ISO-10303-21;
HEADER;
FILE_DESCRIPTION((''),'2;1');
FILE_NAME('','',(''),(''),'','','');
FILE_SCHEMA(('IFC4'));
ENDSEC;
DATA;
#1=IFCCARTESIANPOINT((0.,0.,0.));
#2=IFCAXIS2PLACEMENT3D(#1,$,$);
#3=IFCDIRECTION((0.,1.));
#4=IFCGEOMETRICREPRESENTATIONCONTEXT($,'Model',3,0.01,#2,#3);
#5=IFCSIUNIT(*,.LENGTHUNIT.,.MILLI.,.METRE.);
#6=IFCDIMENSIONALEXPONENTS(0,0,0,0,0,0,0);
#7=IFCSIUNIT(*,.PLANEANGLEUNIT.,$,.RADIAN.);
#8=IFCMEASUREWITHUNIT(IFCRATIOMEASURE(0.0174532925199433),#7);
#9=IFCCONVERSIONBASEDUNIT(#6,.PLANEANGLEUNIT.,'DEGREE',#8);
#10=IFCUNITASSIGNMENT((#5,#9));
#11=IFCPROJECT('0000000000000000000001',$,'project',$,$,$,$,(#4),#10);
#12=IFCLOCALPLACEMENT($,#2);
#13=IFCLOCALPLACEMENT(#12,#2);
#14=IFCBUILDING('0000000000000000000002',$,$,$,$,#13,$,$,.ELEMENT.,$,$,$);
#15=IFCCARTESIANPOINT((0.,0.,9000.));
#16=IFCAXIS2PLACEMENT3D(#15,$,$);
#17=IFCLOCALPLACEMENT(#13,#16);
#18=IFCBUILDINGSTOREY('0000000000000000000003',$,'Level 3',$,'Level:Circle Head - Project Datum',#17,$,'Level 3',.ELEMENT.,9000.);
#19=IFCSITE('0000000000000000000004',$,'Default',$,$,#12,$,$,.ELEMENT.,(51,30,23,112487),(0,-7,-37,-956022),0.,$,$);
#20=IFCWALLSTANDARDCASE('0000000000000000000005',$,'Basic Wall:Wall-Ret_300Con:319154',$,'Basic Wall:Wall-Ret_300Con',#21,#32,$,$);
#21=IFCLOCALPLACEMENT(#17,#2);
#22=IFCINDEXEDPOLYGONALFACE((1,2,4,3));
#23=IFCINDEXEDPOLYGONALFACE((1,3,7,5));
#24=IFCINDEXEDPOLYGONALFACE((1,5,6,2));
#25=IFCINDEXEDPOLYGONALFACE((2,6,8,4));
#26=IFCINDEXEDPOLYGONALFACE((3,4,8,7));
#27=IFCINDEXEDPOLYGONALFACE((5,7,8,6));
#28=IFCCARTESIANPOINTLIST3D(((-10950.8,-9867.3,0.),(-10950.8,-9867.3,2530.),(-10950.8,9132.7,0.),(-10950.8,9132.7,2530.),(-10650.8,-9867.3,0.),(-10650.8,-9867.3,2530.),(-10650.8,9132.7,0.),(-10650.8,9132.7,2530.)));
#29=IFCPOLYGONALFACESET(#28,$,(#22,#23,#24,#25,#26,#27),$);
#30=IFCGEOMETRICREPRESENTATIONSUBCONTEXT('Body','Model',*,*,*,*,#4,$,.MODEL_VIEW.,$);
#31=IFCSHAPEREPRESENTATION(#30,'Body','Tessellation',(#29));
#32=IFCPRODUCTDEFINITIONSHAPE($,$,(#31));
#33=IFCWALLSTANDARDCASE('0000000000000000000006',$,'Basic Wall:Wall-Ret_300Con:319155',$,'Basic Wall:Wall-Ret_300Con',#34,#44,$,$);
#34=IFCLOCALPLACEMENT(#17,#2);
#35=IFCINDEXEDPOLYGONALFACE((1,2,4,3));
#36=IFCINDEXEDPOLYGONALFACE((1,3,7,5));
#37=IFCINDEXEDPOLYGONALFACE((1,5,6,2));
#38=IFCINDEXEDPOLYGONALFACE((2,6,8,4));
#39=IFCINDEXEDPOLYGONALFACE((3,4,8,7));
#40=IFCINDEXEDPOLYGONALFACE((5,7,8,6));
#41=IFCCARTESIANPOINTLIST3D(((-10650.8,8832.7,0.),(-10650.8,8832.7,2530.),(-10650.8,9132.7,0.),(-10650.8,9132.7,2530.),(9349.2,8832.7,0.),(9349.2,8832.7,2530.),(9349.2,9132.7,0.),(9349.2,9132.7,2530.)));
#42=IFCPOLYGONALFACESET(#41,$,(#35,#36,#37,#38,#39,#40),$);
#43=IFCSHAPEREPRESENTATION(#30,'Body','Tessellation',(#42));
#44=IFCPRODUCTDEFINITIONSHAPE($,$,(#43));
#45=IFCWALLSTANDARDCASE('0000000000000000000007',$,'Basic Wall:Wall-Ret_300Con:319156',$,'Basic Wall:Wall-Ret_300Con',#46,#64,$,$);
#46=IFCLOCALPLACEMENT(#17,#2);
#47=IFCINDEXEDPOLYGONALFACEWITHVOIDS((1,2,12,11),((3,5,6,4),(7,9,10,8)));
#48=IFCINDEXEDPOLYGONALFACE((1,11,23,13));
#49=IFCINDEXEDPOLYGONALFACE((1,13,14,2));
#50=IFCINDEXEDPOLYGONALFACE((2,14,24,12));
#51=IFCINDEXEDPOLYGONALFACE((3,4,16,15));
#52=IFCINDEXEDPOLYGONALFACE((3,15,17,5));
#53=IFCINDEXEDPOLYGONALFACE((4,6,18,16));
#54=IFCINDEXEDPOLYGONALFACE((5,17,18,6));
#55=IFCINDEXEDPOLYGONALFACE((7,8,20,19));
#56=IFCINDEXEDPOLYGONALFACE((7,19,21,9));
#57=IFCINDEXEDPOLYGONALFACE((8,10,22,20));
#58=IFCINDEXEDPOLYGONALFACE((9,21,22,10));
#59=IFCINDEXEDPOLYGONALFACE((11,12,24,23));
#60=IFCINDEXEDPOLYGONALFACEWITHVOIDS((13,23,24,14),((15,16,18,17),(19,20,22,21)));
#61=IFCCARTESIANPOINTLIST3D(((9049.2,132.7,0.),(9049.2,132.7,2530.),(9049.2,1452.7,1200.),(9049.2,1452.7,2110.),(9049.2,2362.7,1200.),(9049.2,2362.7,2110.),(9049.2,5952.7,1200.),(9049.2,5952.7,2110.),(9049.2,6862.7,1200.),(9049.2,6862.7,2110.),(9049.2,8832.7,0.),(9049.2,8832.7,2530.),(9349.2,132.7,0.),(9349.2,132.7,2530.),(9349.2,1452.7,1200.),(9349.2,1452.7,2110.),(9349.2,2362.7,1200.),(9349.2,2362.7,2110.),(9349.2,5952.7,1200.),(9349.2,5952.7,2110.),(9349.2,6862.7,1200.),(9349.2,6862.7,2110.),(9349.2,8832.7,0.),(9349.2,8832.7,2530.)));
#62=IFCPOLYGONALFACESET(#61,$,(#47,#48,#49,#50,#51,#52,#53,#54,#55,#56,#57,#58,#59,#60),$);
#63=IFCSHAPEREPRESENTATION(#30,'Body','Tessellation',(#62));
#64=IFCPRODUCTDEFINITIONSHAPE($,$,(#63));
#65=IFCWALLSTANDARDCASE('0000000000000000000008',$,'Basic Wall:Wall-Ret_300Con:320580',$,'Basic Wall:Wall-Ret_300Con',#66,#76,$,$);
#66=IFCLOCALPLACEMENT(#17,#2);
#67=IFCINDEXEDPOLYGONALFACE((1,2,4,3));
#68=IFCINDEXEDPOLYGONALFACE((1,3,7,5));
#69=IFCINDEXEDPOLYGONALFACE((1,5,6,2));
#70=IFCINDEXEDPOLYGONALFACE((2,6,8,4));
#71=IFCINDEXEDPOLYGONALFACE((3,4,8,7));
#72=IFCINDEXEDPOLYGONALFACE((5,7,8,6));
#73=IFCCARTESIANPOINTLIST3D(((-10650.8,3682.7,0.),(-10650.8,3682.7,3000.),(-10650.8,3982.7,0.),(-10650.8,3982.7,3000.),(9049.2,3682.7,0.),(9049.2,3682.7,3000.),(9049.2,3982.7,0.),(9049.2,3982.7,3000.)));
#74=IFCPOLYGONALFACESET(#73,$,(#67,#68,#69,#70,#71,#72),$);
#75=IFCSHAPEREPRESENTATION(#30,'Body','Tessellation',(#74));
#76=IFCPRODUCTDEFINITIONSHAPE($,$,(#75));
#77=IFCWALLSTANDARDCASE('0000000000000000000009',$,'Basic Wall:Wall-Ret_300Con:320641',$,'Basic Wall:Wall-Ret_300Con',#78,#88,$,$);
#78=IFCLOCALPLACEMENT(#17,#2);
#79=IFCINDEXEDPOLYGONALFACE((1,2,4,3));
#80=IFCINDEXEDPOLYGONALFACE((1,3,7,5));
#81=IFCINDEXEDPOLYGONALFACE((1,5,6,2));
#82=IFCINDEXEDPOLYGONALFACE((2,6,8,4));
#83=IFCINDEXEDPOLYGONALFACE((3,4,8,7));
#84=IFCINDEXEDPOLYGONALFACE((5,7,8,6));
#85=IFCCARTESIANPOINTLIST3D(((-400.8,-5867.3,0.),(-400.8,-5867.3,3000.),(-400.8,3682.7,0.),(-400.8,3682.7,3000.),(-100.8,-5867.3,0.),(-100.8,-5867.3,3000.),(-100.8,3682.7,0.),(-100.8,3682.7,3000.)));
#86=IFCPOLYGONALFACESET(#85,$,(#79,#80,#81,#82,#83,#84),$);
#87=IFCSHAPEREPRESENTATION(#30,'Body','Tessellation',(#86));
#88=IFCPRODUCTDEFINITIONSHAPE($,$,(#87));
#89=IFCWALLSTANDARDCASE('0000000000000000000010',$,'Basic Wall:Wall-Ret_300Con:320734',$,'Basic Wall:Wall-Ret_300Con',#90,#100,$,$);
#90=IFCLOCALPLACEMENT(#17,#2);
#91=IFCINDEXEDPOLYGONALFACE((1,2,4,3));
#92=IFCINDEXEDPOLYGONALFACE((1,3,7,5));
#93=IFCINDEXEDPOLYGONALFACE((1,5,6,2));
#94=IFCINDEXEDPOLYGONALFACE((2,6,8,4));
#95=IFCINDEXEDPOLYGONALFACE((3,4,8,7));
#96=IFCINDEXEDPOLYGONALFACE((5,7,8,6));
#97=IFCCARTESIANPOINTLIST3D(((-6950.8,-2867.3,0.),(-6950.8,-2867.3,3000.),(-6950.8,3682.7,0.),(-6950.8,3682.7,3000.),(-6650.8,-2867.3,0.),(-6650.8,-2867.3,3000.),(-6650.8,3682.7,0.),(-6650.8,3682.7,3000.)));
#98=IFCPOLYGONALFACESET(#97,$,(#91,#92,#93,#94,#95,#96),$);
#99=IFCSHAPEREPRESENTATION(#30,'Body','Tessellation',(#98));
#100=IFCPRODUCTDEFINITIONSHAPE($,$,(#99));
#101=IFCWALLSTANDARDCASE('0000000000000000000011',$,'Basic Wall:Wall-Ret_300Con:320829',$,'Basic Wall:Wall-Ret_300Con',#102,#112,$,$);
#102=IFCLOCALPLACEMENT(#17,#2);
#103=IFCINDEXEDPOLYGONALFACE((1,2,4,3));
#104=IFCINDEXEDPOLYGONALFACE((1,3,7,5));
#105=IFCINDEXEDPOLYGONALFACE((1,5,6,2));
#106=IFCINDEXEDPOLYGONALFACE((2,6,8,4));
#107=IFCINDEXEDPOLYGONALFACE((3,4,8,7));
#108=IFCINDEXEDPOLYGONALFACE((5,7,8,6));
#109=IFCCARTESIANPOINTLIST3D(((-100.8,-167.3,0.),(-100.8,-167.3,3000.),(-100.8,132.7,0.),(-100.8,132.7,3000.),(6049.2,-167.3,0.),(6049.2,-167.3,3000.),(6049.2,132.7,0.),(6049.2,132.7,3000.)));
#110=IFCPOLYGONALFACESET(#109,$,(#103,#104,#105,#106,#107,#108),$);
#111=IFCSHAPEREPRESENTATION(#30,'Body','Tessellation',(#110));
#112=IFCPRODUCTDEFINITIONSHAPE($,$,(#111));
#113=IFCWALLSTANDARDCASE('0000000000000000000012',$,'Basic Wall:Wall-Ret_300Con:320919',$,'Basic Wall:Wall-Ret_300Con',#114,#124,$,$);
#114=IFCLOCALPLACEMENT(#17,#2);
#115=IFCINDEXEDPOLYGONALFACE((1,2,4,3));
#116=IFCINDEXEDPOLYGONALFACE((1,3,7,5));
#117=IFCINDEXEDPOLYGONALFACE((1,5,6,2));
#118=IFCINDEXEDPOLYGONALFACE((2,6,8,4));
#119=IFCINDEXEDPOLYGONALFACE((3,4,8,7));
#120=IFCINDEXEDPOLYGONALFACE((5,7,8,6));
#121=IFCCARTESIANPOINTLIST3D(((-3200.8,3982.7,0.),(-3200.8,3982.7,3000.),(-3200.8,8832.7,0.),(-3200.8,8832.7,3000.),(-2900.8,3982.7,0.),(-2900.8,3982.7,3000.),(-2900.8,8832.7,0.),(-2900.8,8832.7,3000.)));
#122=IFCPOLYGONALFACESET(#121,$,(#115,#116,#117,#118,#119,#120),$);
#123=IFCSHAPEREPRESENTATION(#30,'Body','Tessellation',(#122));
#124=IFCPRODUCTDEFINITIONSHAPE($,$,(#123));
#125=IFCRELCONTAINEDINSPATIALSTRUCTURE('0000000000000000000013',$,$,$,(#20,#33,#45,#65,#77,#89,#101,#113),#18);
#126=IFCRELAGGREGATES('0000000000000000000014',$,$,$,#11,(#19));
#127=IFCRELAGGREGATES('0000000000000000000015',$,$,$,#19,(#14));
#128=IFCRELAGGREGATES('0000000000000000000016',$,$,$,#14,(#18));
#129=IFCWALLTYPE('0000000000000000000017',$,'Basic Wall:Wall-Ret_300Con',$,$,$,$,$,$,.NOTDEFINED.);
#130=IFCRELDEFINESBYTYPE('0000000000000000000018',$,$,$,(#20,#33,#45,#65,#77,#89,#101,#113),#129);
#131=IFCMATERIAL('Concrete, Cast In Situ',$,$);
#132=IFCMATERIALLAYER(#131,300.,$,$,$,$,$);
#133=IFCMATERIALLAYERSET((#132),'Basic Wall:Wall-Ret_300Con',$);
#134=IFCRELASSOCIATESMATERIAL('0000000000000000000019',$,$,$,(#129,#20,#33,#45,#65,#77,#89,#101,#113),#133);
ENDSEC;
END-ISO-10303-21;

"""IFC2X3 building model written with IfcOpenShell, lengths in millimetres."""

from ifc_helpers import new_model, entity, si_unit, converted_unit, direction, frame, frame_2d, origin, place, context, subcontext, project, spatial, polyline, rectangle, extrude, clip, bounded_halfspace, material, layer, layer_set, layer_usage, type_object, element, save


model = new_model("IFC2X3")

# Units and contexts
model_context = context("Model", 3, precision=0.01, world=origin(), true_north=direction((0.0, 1.0)))
body_context = subcontext(model_context, "Body", "Model", "MODEL_VIEW")
ifc_project = project(units=[si_unit("LENGTHUNIT", "METRE", prefix="MILLI"), converted_unit("PLANEANGLEUNIT", "DEGREE", entity("IfcRatioMeasure", 0.0174532925199433), si_unit("PLANEANGLEUNIT", "RADIAN"), dimensions=[0, 0, 0, 0, 0, 0, 0])], contexts=[model_context])

# Site, building, storey
site_placement = place(None, origin())
site = spatial("IfcSite", under=ifc_project, at=site_placement, Name="Default", CompositionType="ELEMENT", RefLatitude=(51, 30, 23, 112487), RefLongitude=(0, -7, -37, -956022), RefElevation=0.0)
building_placement = place(site_placement, origin())
building = spatial("IfcBuilding", under=site, at=building_placement, CompositionType="ELEMENT")
storey_placement = place(building_placement, frame((0.0, 0.0, 9000.0)))
storey = spatial("IfcBuildingStorey", under=building, at=storey_placement, Name="Level 3", ObjectType="Level:Circle Head - Project Datum", LongName="Level 3", CompositionType="ELEMENT", Elevation=9000.0)

# Shared definitions
ifc_material_1 = material(Name="Concrete, Cast In Situ")
ifc_layer_1 = layer(ifc_material_1, 300.0)
ifc_layer_set_1 = layer_set([ifc_layer_1], Name="Basic Wall:Wall-Ret_300Con")
wall_type = type_object("IfcWallType", Name="Basic Wall:Wall-Ret_300Con", PredefinedType="NOTDEFINED", material=ifc_layer_set_1)

# Walls
ifc_layer_usage_1 = layer_usage(ifc_layer_set_1, "AXIS2", "NEGATIVE", 150.0)
wall_1_placement = place(storey_placement, frame((-10800.8, -9867.3, 0.0), z_axis=(0.0, 0.0, 1.0), x_axis=(0.0, 1.0, 0.0)))
element("IfcWallStandardCase", 1, at=wall_1_placement, inside=storey, type_object=wall_type, material=ifc_layer_usage_1, Name="Basic Wall:Wall-Ret_300Con:319154", ObjectType="Basic Wall:Wall-Ret_300Con", context=body_context, shape_type="Clipping", body=[
    clip(extrude(rectangle(XDim=19000.0, YDim=300.0, at=frame_2d((9500.0, 0.0), x_axis=(-1.0, 0.0))), origin(), (0.0, 0.0, 1.0), 2530.0), bounded_halfspace(frame((0.0, -150.0, 2530.0), z_axis=(0.0, 0.0, -1.0), x_axis=(0.0, -1.0, 0.0)), True, frame((0.0, -150.0, 2530.0)), polyline([(0.0, 0.0), (18700.0, 0.0), (19000.0, 0.0), (19000.0, 300.0), (0.0, 300.0), (0.0, 0.0)]))),
])
ifc_layer_usage_2 = layer_usage(ifc_layer_set_1, "AXIS2", "NEGATIVE", 150.0)
wall_2_placement = place(storey_placement, frame((-10650.8, 8982.7, 0.0)))
element("IfcWallStandardCase", 2, at=wall_2_placement, inside=storey, type_object=wall_type, material=ifc_layer_usage_2, Name="Basic Wall:Wall-Ret_300Con:319155", ObjectType="Basic Wall:Wall-Ret_300Con", context=body_context, shape_type="Clipping", body=[
    clip(extrude(rectangle(XDim=20000.0, YDim=300.0, at=frame_2d((10000.0, 0.0), x_axis=(-1.0, 0.0))), origin(), (0.0, 0.0, 1.0), 2530.0), bounded_halfspace(frame((0.0, -150.0, 2530.0), z_axis=(0.0, 0.0, -1.0), x_axis=(1.0, 0.0, 0.0)), True, frame((0.0, -150.0, 2530.0)), polyline([(0.0, 0.0), (19700.0, 0.0), (19998.7, 0.0), (19998.7, 300.0), (0.0, 300.0), (0.0, 0.0)]))),
])

# Wall, openings
ifc_layer_usage_3 = layer_usage(ifc_layer_set_1, "AXIS2", "NEGATIVE", 150.0)
wall_3_placement = place(storey_placement, frame((9199.2, 8832.7, 0.0), z_axis=(0.0, 0.0, 1.0), x_axis=(0.0, -1.0, 0.0)))
wall_3 = element("IfcWallStandardCase", 3, at=wall_3_placement, inside=storey, type_object=wall_type, material=ifc_layer_usage_3, Name="Basic Wall:Wall-Ret_300Con:319156", ObjectType="Basic Wall:Wall-Ret_300Con", context=body_context, shape_type="Clipping", body=[
    clip(extrude(rectangle(XDim=8700.0, YDim=300.0, at=frame_2d((4350.0, 0.0), x_axis=(-1.0, 0.0))), origin(), (0.0, 0.0, 1.0), 2530.0), bounded_halfspace(frame((0.0, -150.0, 2530.0), z_axis=(0.0, 0.0, -1.0), x_axis=(0.0, 1.0, 0.0)), True, frame((0.0, -150.0, 2530.0)), polyline([(0.0, 0.0), (8700.0, 0.0), (8700.0, 298.7), (0.0, 298.7), (0.0, 0.0)]))),
])
opening_1_placement = place(wall_3_placement, frame((1970.0, -150.0, 1200.0)))
element("IfcOpeningElement", 4, at=opening_1_placement, cuts=wall_3, ObjectType="Opening", context=body_context, shape_type="SweptSolid", body=[
    extrude(rectangle(XDim=910.0, YDim=910.0, at=frame_2d((455.0, 455.0), x_axis=(-1.0, 0.0))), frame((0.0, 0.0, 0.0), z_axis=(0.0, 1.0, 0.0), x_axis=(0.0, 0.0, 1.0)), (0.0, 0.0, 1.0), 300.0),
])
opening_2_placement = place(wall_3_placement, frame((6470.0, -150.0, 1200.0)))
element("IfcOpeningElement", 5, at=opening_2_placement, cuts=wall_3, ObjectType="Opening", context=body_context, shape_type="SweptSolid", body=[
    extrude(rectangle(XDim=910.0, YDim=910.0, at=frame_2d((455.0, 455.0), x_axis=(-1.0, 0.0))), frame((0.0, 0.0, 0.0), z_axis=(0.0, 1.0, 0.0), x_axis=(0.0, 0.0, 1.0)), (0.0, 0.0, 1.0), 300.0),
])

# Walls
ifc_layer_usage_4 = layer_usage(ifc_layer_set_1, "AXIS2", "NEGATIVE", 150.0)
wall_4_placement = place(storey_placement, frame((-10650.8, 3832.7, 0.0)))
element("IfcWallStandardCase", 6, at=wall_4_placement, inside=storey, type_object=wall_type, material=ifc_layer_usage_4, Name="Basic Wall:Wall-Ret_300Con:320580", ObjectType="Basic Wall:Wall-Ret_300Con", context=body_context, shape_type="SweptSolid", body=[
    extrude(rectangle(XDim=19700.0, YDim=300.0, at=frame_2d((9850.0, 0.0), x_axis=(-1.0, 0.0))), origin(), (0.0, 0.0, 1.0), 3000.0),
])
ifc_layer_usage_5 = layer_usage(ifc_layer_set_1, "AXIS2", "NEGATIVE", 150.0)
wall_5_placement = place(storey_placement, frame((-250.8, 3682.7, 0.0), z_axis=(0.0, 0.0, 1.0), x_axis=(0.0, -1.0, 0.0)))
element("IfcWallStandardCase", 7, at=wall_5_placement, inside=storey, type_object=wall_type, material=ifc_layer_usage_5, Name="Basic Wall:Wall-Ret_300Con:320641", ObjectType="Basic Wall:Wall-Ret_300Con", context=body_context, shape_type="SweptSolid", body=[
    extrude(rectangle(XDim=9550.0, YDim=300.0, at=frame_2d((4775.0, 0.0), x_axis=(-1.0, 0.0))), origin(), (0.0, 0.0, 1.0), 3000.0),
])
ifc_layer_usage_6 = layer_usage(ifc_layer_set_1, "AXIS2", "NEGATIVE", 150.0)
wall_6_placement = place(storey_placement, frame((-6800.8, -2867.3, 0.0), z_axis=(0.0, 0.0, 1.0), x_axis=(0.0, 1.0, 0.0)))
element("IfcWallStandardCase", 8, at=wall_6_placement, inside=storey, type_object=wall_type, material=ifc_layer_usage_6, Name="Basic Wall:Wall-Ret_300Con:320734", ObjectType="Basic Wall:Wall-Ret_300Con", context=body_context, shape_type="SweptSolid", body=[
    extrude(rectangle(XDim=6550.0, YDim=300.0, at=frame_2d((3275.0, 0.0), x_axis=(-1.0, 0.0))), origin(), (0.0, 0.0, 1.0), 3000.0),
])
ifc_layer_usage_7 = layer_usage(ifc_layer_set_1, "AXIS2", "NEGATIVE", 150.0)
wall_7_placement = place(storey_placement, frame((6049.2, -17.3, 0.0), z_axis=(0.0, 0.0, 1.0), x_axis=(-1.0, 0.0, 0.0)))
element("IfcWallStandardCase", 9, at=wall_7_placement, inside=storey, type_object=wall_type, material=ifc_layer_usage_7, Name="Basic Wall:Wall-Ret_300Con:320829", ObjectType="Basic Wall:Wall-Ret_300Con", context=body_context, shape_type="SweptSolid", body=[
    extrude(rectangle(XDim=6150.0, YDim=300.0, at=frame_2d((3075.0, 0.0), x_axis=(-1.0, 0.0))), origin(), (0.0, 0.0, 1.0), 3000.0),
])
ifc_layer_usage_8 = layer_usage(ifc_layer_set_1, "AXIS2", "NEGATIVE", 150.0)
wall_8_placement = place(storey_placement, frame((-3050.8, 3982.7, 0.0), z_axis=(0.0, 0.0, 1.0), x_axis=(0.0, 1.0, 0.0)))
element("IfcWallStandardCase", 10, at=wall_8_placement, inside=storey, type_object=wall_type, material=ifc_layer_usage_8, Name="Basic Wall:Wall-Ret_300Con:320919", ObjectType="Basic Wall:Wall-Ret_300Con", context=body_context, shape_type="SweptSolid", body=[
    extrude(rectangle(XDim=4850.0, YDim=300.0, at=frame_2d((2425.0, 0.0), x_axis=(-1.0, 0.0))), origin(), (0.0, 0.0, 1.0), 3000.0),
])

save(model, "model.ifc")
